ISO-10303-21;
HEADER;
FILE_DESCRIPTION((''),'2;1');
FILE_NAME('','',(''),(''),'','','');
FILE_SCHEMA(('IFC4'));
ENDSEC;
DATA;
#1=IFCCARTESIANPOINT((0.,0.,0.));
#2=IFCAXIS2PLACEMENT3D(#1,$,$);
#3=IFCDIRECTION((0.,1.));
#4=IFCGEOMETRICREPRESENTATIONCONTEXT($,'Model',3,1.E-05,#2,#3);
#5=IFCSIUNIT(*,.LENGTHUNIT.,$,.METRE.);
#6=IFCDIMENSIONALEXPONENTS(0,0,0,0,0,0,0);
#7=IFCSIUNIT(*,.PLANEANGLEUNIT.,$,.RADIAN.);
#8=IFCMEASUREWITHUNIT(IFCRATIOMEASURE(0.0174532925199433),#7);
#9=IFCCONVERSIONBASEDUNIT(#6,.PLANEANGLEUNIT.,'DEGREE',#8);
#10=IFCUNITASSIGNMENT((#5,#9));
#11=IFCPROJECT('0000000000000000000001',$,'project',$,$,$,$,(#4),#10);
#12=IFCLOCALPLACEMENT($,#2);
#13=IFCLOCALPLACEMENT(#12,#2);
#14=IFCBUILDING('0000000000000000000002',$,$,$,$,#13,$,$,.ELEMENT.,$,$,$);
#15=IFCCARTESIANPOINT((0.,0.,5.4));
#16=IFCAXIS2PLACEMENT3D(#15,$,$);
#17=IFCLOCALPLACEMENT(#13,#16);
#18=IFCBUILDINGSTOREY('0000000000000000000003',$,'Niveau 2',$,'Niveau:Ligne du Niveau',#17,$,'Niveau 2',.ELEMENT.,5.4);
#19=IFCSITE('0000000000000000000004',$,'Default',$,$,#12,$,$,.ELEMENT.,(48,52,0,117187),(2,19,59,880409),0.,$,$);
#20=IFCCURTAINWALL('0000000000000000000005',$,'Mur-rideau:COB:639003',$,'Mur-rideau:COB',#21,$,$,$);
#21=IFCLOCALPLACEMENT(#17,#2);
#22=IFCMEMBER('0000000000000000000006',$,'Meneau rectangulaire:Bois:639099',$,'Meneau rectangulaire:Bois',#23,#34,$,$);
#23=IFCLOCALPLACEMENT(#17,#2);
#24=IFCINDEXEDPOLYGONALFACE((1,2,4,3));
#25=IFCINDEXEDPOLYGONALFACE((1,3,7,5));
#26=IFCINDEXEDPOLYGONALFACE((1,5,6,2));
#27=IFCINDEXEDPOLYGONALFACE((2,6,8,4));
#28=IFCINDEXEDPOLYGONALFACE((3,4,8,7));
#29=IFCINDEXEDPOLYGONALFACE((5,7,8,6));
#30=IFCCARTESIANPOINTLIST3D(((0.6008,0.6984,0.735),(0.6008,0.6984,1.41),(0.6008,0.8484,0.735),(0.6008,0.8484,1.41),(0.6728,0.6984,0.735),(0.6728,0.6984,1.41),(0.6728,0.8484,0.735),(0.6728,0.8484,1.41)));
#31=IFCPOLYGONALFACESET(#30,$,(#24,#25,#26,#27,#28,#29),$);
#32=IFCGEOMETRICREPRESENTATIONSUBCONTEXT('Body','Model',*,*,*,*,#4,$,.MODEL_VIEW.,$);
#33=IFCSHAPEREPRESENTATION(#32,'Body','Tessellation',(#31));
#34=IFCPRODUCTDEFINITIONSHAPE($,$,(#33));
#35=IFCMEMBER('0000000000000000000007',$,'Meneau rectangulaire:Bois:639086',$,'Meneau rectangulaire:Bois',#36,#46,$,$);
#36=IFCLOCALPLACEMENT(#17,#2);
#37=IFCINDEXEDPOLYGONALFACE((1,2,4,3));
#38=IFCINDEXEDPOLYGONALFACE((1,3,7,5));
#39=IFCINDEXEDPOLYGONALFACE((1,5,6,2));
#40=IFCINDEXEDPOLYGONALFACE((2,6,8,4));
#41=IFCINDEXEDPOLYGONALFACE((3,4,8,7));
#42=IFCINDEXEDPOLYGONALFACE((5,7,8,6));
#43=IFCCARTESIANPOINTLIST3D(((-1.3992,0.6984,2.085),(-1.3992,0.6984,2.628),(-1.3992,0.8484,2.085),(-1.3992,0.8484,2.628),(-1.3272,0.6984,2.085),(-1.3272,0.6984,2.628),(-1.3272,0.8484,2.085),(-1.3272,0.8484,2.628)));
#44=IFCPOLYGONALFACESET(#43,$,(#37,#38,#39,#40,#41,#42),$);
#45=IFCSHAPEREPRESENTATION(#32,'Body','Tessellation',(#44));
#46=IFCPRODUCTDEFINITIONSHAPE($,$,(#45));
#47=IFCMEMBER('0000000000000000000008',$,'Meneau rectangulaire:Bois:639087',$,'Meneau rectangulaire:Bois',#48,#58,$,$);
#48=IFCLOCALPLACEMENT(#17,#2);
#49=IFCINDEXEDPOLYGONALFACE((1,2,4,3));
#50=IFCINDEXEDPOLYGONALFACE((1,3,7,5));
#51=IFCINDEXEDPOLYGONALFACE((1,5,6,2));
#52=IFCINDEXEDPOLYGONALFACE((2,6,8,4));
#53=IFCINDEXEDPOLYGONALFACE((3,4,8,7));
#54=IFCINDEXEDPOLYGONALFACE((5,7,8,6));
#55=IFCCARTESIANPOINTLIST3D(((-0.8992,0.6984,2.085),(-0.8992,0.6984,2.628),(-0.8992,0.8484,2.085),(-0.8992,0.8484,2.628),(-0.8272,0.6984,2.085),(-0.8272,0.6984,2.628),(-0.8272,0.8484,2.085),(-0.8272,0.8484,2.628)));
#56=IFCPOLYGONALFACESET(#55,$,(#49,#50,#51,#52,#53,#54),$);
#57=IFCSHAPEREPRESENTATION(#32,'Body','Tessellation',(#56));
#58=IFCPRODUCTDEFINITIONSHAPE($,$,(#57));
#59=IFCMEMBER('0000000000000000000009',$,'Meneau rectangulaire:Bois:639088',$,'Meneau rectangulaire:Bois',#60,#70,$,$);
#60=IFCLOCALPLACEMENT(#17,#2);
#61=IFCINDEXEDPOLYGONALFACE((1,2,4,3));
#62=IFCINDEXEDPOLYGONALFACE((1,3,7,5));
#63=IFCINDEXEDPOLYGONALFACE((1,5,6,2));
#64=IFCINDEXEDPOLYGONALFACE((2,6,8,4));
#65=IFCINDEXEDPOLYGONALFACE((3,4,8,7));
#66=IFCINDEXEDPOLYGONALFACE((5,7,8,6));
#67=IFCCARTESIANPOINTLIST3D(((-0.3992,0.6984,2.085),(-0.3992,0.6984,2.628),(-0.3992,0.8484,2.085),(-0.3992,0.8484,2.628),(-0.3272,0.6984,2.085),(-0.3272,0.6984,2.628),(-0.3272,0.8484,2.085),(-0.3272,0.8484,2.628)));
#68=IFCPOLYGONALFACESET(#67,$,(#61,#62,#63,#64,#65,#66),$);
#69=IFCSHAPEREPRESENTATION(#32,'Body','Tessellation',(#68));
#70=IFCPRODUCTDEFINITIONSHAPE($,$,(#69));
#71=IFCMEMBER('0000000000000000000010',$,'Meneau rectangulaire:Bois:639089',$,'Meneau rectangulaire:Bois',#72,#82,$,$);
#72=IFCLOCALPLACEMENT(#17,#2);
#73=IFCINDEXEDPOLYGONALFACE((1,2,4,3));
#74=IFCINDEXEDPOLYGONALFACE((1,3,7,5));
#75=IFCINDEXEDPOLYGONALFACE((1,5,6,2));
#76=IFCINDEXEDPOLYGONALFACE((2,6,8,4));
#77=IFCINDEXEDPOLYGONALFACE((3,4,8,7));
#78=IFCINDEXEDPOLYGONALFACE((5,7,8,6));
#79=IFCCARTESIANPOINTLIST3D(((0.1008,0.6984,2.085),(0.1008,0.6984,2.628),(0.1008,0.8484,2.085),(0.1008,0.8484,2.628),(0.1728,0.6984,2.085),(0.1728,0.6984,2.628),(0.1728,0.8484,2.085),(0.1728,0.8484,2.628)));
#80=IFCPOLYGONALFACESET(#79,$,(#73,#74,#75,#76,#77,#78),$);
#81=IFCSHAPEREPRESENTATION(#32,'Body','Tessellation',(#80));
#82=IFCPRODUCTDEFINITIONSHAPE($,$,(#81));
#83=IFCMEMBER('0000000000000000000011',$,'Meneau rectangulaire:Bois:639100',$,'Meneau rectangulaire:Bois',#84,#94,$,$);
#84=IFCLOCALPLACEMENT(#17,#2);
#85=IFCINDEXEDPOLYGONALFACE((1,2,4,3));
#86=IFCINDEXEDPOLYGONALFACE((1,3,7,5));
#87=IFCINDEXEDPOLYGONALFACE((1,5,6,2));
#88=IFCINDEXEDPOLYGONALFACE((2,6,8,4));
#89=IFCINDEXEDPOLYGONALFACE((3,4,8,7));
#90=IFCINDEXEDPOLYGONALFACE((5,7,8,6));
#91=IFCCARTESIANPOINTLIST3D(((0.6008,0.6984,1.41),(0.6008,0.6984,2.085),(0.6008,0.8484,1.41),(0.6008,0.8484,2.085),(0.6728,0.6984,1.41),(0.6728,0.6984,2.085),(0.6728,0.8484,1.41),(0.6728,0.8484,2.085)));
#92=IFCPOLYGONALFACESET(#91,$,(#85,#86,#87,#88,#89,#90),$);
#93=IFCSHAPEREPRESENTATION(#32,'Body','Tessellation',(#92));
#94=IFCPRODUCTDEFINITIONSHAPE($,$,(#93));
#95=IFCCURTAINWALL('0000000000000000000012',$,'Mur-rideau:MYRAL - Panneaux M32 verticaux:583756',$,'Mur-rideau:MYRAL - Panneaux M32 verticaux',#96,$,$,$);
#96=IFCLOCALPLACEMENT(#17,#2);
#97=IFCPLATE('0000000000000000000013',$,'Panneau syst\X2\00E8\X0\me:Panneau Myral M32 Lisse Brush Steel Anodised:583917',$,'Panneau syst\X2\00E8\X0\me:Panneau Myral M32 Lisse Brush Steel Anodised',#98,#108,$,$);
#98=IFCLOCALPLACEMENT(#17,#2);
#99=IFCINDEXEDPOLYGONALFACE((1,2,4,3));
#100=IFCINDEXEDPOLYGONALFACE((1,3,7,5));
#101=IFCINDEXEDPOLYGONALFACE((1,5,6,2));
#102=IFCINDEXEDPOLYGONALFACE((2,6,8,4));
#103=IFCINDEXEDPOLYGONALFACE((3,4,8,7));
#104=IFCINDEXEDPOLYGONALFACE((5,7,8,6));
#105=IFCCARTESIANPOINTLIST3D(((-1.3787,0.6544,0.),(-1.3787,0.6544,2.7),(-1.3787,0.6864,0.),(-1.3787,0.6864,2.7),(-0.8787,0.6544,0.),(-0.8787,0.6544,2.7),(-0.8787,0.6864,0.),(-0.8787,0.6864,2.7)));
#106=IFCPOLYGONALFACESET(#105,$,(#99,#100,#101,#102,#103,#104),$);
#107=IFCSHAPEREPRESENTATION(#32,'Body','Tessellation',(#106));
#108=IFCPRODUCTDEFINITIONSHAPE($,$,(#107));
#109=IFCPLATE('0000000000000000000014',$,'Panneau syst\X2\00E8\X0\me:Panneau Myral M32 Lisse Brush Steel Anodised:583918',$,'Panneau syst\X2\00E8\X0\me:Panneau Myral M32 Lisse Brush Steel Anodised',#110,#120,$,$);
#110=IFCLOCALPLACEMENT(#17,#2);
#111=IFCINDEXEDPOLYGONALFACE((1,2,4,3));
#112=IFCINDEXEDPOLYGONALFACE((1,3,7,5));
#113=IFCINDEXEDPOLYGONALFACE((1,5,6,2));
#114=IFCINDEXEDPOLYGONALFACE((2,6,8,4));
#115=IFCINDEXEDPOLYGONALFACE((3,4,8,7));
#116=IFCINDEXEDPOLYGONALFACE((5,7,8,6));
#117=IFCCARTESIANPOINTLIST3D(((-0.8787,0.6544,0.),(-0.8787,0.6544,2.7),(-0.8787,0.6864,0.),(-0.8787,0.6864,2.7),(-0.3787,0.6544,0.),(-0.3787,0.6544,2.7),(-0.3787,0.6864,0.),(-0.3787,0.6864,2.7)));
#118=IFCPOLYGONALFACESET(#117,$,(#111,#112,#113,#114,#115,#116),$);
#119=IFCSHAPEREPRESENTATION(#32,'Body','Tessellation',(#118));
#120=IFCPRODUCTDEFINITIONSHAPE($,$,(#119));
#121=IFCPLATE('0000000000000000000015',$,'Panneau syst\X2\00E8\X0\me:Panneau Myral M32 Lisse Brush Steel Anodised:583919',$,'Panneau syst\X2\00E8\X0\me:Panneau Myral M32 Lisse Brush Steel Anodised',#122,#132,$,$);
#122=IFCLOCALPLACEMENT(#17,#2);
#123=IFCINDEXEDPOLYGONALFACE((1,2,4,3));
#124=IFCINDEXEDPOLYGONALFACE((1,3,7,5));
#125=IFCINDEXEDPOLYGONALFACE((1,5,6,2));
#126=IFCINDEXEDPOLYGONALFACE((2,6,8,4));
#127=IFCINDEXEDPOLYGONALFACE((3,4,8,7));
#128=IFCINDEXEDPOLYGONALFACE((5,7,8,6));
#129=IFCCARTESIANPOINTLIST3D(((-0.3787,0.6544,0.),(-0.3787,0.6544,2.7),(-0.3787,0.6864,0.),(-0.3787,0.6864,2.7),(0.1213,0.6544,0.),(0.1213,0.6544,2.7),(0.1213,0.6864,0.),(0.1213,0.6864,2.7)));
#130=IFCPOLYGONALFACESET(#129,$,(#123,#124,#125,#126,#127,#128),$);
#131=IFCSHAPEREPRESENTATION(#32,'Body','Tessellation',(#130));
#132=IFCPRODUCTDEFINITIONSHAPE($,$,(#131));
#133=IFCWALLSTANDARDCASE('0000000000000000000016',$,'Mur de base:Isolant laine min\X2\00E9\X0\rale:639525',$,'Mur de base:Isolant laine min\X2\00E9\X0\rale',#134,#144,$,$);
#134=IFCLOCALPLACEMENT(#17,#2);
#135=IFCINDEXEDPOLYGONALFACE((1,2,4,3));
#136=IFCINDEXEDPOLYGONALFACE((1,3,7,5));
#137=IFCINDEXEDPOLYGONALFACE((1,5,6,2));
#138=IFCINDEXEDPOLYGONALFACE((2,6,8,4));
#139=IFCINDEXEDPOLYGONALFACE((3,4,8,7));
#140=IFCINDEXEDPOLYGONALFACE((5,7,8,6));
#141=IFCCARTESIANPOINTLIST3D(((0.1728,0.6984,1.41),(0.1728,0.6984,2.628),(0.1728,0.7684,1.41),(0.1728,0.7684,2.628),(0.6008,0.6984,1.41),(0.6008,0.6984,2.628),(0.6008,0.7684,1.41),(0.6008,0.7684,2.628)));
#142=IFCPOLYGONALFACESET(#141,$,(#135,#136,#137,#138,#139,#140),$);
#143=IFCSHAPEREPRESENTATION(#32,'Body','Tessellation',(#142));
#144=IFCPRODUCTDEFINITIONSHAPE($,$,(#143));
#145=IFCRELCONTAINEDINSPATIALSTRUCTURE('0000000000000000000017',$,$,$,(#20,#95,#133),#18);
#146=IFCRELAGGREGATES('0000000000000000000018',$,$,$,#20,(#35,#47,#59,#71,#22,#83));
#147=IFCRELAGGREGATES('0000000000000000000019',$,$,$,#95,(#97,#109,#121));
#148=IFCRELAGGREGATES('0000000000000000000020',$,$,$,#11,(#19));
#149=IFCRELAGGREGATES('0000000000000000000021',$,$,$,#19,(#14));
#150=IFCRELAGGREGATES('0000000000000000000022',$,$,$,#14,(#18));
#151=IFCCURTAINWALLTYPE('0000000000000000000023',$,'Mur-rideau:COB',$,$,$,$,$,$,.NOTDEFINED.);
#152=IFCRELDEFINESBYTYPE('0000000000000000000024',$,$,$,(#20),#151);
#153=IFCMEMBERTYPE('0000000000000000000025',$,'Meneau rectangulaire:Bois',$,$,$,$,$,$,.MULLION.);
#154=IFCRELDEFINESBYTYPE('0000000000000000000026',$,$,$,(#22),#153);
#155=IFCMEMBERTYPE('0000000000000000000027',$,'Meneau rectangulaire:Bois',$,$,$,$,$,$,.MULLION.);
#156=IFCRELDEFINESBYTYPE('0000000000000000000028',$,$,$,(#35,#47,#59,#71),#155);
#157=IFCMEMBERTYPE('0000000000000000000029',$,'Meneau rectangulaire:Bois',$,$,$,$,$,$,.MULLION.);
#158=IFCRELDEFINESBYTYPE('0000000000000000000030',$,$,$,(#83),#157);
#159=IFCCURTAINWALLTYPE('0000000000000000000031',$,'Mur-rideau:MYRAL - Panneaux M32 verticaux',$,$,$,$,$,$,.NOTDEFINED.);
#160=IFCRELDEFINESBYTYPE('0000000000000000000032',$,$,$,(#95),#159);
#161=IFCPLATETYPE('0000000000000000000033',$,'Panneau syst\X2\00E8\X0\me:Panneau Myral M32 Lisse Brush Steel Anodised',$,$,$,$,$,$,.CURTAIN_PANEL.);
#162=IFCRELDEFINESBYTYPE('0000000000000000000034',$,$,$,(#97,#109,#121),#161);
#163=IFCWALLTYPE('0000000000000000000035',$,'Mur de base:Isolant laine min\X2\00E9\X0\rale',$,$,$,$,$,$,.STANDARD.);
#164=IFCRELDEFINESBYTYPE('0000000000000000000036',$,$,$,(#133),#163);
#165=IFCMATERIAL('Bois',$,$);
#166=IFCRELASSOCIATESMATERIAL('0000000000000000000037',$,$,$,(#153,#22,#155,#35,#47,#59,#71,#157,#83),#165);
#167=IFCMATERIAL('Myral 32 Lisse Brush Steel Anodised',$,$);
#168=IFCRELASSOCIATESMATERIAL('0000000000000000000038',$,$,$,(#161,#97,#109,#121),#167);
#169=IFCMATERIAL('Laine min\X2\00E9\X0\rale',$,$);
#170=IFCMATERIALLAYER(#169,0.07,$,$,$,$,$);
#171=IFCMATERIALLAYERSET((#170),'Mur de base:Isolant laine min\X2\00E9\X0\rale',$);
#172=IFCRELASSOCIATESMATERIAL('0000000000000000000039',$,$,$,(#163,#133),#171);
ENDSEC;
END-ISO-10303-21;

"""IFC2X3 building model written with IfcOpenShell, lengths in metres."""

from ifc_helpers import new_model, entity, si_unit, converted_unit, direction, frame, frame_2d, origin, origin_2d_with_axis, place, context, subcontext, project, spatial, rectangle, extrude, source, transform, mapped, material, layer, layer_set, layer_usage, type_object, type_shapes, element, aggregate, save


model = new_model("IFC2X3")

# Units and contexts
model_context = context("Model", 3, precision=1e-05, world=origin(), true_north=direction((0.0, 1.0)))
body_context = subcontext(model_context, "Body", "Model", "MODEL_VIEW")
ifc_project = project(units=[si_unit("LENGTHUNIT", "METRE"), converted_unit("PLANEANGLEUNIT", "DEGREE", entity("IfcRatioMeasure", 0.0174532925199433), si_unit("PLANEANGLEUNIT", "RADIAN"), dimensions=[0, 0, 0, 0, 0, 0, 0])], contexts=[model_context])

# Site, building, storey
site_placement = place(None, origin())
site = spatial("IfcSite", under=ifc_project, at=site_placement, Name="Default", CompositionType="ELEMENT", RefLatitude=(48, 52, 0, 117187), RefLongitude=(2, 19, 59, 880409), RefElevation=0.0)
building_placement = place(site_placement, origin())
building = spatial("IfcBuilding", under=site, at=building_placement, CompositionType="ELEMENT")
storey_placement = place(building_placement, frame((0.0, 0.0, 5.4)))
storey = spatial("IfcBuildingStorey", under=building, at=storey_placement, Name="Niveau 2", ObjectType="Niveau:Ligne du Niveau", LongName="Niveau 2", CompositionType="ELEMENT", Elevation=5.4)

# Curtain wall, members
curtain_wall_type_1 = type_object("IfcCurtainWallType", Name="Mur-rideau:COB", PredefinedType="NOTDEFINED")
curtain_wall_1_placement = place(storey_placement, frame((0.0, 0.0, -5.4)))
curtain_wall_1 = element("IfcCurtainWall", 1, at=curtain_wall_1_placement, inside=storey, type_object=curtain_wall_type_1, Name="Mur-rideau:COB:639003", ObjectType="Mur-rideau:COB")
ifc_material_1 = material(Name="Bois")
member_type_1 = type_object("IfcMemberType", Name="Meneau rectangulaire:Bois", PredefinedType="MULLION", material=ifc_material_1)
shared_shape_1 = source(origin(), body_context, "Body", "SweptSolid", [
    extrude(rectangle(XDim=0.15, YDim=0.072, at=origin_2d_with_axis()), frame((-0.024, 0.0, -0.675), z_axis=(0.0, 0.0, 1.0), x_axis=(0.0, -1.0, 0.0)), (0.0, 0.0, 1.0), 0.675),
])
type_shapes(member_type_1, [shared_shape_1])
member_1_placement = place(storey_placement, frame((0.6608, 0.7734, 0.735), z_axis=(0.0, 0.0, -1.0), x_axis=(1.0, 0.0, 0.0)))
member_1 = element("IfcMember", 2, at=member_1_placement, type_object=member_type_1, material=ifc_material_1, Name="Meneau rectangulaire:Bois:639099", ObjectType="Meneau rectangulaire:Bois", context=body_context, shape_type="MappedRepresentation", body=[
    mapped(shared_shape_1, transform((0.0, 0.0, 0.0), scale=1.0)),
])
member_type_2 = type_object("IfcMemberType", Name="Meneau rectangulaire:Bois", PredefinedType="MULLION", material=ifc_material_1)
shared_shape_2 = source(origin(), body_context, "Body", "SweptSolid", [
    extrude(rectangle(XDim=0.15, YDim=0.072, at=origin_2d_with_axis()), frame((-0.024, 0.0, -0.543), z_axis=(0.0, 0.0, 1.0), x_axis=(0.0, -1.0, 0.0)), (0.0, 0.0, 1.0), 0.543),
])
type_shapes(member_type_2, [shared_shape_2])
member_2_placement = place(storey_placement, frame((-1.3392, 0.7734, 2.085), z_axis=(0.0, 0.0, -1.0), x_axis=(1.0, 0.0, 0.0)))
member_2 = element("IfcMember", 3, at=member_2_placement, type_object=member_type_2, material=ifc_material_1, Name="Meneau rectangulaire:Bois:639086", ObjectType="Meneau rectangulaire:Bois", context=body_context, shape_type="MappedRepresentation", body=[
    mapped(shared_shape_2, transform((0.0, 0.0, 0.0), scale=1.0)),
])
member_3_placement = place(storey_placement, frame((-0.8392, 0.7734, 2.085), z_axis=(0.0, 0.0, -1.0), x_axis=(1.0, 0.0, 0.0)))
member_3 = element("IfcMember", 4, at=member_3_placement, type_object=member_type_2, material=ifc_material_1, Name="Meneau rectangulaire:Bois:639087", ObjectType="Meneau rectangulaire:Bois", context=body_context, shape_type="MappedRepresentation", body=[
    mapped(shared_shape_2, transform((0.0, 0.0, 0.0), scale=1.0)),
])
member_4_placement = place(storey_placement, frame((-0.3392, 0.7734, 2.085), z_axis=(0.0, 0.0, -1.0), x_axis=(1.0, 0.0, 0.0)))
member_4 = element("IfcMember", 5, at=member_4_placement, type_object=member_type_2, material=ifc_material_1, Name="Meneau rectangulaire:Bois:639088", ObjectType="Meneau rectangulaire:Bois", context=body_context, shape_type="MappedRepresentation", body=[
    mapped(shared_shape_2, transform((0.0, 0.0, 0.0), scale=1.0)),
])
member_5_placement = place(storey_placement, frame((0.1608, 0.7734, 2.085), z_axis=(0.0, 0.0, -1.0), x_axis=(1.0, 0.0, 0.0)))
member_5 = element("IfcMember", 6, at=member_5_placement, type_object=member_type_2, material=ifc_material_1, Name="Meneau rectangulaire:Bois:639089", ObjectType="Meneau rectangulaire:Bois", context=body_context, shape_type="MappedRepresentation", body=[
    mapped(shared_shape_2, transform((0.0, 0.0, 0.0), scale=1.0)),
])
member_type_3 = type_object("IfcMemberType", Name="Meneau rectangulaire:Bois", PredefinedType="MULLION", material=ifc_material_1)
shared_shape_3 = source(origin(), body_context, "Body", "SweptSolid", [
    extrude(rectangle(XDim=0.15, YDim=0.072, at=origin_2d_with_axis()), frame((-0.024, 0.0, -0.675), z_axis=(0.0, 0.0, 1.0), x_axis=(0.0, -1.0, 0.0)), (0.0, 0.0, 1.0), 0.675),
])
type_shapes(member_type_3, [shared_shape_3])
member_6_placement = place(storey_placement, frame((0.6608, 0.7734, 1.41), z_axis=(0.0, 0.0, -1.0), x_axis=(1.0, 0.0, 0.0)))
member_6 = element("IfcMember", 7, at=member_6_placement, type_object=member_type_3, material=ifc_material_1, Name="Meneau rectangulaire:Bois:639100", ObjectType="Meneau rectangulaire:Bois", context=body_context, shape_type="MappedRepresentation", body=[
    mapped(shared_shape_3, transform((0.0, 0.0, 0.0), scale=1.0)),
])
aggregate(curtain_wall_1, [member_2, member_3, member_4, member_5, member_1, member_6])

# Curtain wall, plates
curtain_wall_type_2 = type_object("IfcCurtainWallType", Name="Mur-rideau:MYRAL - Panneaux M32 verticaux", PredefinedType="NOTDEFINED")
curtain_wall_2_placement = place(storey_placement, frame((0.0, 0.0, -5.4)))
curtain_wall_2 = element("IfcCurtainWall", 8, at=curtain_wall_2_placement, inside=storey, type_object=curtain_wall_type_2, Name="Mur-rideau:MYRAL - Panneaux M32 verticaux:583756", ObjectType="Mur-rideau:MYRAL - Panneaux M32 verticaux")
ifc_material_2 = material(Name="Myral 32 Lisse Brush Steel Anodised")
plate_type = type_object("IfcPlateType", Name="Panneau système:Panneau Myral M32 Lisse Brush Steel Anodised", PredefinedType="CURTAIN_PANEL", material=ifc_material_2)
shared_shape_4 = source(origin(), body_context, "Body", "SweptSolid", [
    extrude(rectangle(XDim=0.032, YDim=0.5, at=origin_2d_with_axis()), frame((0.0, -0.016, 0.0), z_axis=(0.0, 0.0, 1.0), x_axis=(0.0, 1.0, 0.0)), (0.0, 0.0, 1.0), 2.7),
])
type_shapes(plate_type, [shared_shape_4])
plate_1_placement = place(curtain_wall_2_placement, frame((-1.1287, 0.6864, 5.4)))
plate_1 = element("IfcPlate", 9, at=plate_1_placement, type_object=plate_type, material=ifc_material_2, Name="Panneau système:Panneau Myral M32 Lisse Brush Steel Anodised:583917", ObjectType="Panneau système:Panneau Myral M32 Lisse Brush Steel Anodised", context=body_context, shape_type="MappedRepresentation", body=[
    mapped(shared_shape_4, transform((0.0, 0.0, 0.0), scale=1.0)),
])
plate_2_placement = place(curtain_wall_2_placement, frame((-0.6287, 0.6864, 5.4)))
plate_2 = element("IfcPlate", 10, at=plate_2_placement, type_object=plate_type, material=ifc_material_2, Name="Panneau système:Panneau Myral M32 Lisse Brush Steel Anodised:583918", ObjectType="Panneau système:Panneau Myral M32 Lisse Brush Steel Anodised", context=body_context, shape_type="MappedRepresentation", body=[
    mapped(shared_shape_4, transform((0.0, 0.0, 0.0), scale=1.0)),
])
plate_3_placement = place(curtain_wall_2_placement, frame((-0.1287, 0.6864, 5.4)))
plate_3 = element("IfcPlate", 11, at=plate_3_placement, type_object=plate_type, material=ifc_material_2, Name="Panneau système:Panneau Myral M32 Lisse Brush Steel Anodised:583919", ObjectType="Panneau système:Panneau Myral M32 Lisse Brush Steel Anodised", context=body_context, shape_type="MappedRepresentation", body=[
    mapped(shared_shape_4, transform((0.0, 0.0, 0.0), scale=1.0)),
])
aggregate(curtain_wall_2, [plate_1, plate_2, plate_3])

# Wall
ifc_material_3 = material(Name="Laine minérale")
ifc_layer = layer(ifc_material_3, 0.07)
ifc_layer_set = layer_set([ifc_layer], Name="Mur de base:Isolant laine minérale")
ifc_layer_usage = layer_usage(ifc_layer_set, "AXIS2", "NEGATIVE", 0.035)
wall_type = type_object("IfcWallType", Name="Mur de base:Isolant laine minérale", PredefinedType="STANDARD", material=ifc_layer_set)
wall_placement = place(storey_placement, frame((0.1728, 0.7334, 1.41)))
element("IfcWallStandardCase", 12, at=wall_placement, inside=storey, type_object=wall_type, material=ifc_layer_usage, Name="Mur de base:Isolant laine minérale:639525", ObjectType="Mur de base:Isolant laine minérale", context=body_context, shape_type="SweptSolid", body=[
    extrude(rectangle(XDim=0.428, YDim=0.07, at=frame_2d((0.214, 0.0), x_axis=(-1.0, 0.0))), origin(), (0.0, 0.0, 1.0), 1.218),
])

save(model, "model.ifc")
